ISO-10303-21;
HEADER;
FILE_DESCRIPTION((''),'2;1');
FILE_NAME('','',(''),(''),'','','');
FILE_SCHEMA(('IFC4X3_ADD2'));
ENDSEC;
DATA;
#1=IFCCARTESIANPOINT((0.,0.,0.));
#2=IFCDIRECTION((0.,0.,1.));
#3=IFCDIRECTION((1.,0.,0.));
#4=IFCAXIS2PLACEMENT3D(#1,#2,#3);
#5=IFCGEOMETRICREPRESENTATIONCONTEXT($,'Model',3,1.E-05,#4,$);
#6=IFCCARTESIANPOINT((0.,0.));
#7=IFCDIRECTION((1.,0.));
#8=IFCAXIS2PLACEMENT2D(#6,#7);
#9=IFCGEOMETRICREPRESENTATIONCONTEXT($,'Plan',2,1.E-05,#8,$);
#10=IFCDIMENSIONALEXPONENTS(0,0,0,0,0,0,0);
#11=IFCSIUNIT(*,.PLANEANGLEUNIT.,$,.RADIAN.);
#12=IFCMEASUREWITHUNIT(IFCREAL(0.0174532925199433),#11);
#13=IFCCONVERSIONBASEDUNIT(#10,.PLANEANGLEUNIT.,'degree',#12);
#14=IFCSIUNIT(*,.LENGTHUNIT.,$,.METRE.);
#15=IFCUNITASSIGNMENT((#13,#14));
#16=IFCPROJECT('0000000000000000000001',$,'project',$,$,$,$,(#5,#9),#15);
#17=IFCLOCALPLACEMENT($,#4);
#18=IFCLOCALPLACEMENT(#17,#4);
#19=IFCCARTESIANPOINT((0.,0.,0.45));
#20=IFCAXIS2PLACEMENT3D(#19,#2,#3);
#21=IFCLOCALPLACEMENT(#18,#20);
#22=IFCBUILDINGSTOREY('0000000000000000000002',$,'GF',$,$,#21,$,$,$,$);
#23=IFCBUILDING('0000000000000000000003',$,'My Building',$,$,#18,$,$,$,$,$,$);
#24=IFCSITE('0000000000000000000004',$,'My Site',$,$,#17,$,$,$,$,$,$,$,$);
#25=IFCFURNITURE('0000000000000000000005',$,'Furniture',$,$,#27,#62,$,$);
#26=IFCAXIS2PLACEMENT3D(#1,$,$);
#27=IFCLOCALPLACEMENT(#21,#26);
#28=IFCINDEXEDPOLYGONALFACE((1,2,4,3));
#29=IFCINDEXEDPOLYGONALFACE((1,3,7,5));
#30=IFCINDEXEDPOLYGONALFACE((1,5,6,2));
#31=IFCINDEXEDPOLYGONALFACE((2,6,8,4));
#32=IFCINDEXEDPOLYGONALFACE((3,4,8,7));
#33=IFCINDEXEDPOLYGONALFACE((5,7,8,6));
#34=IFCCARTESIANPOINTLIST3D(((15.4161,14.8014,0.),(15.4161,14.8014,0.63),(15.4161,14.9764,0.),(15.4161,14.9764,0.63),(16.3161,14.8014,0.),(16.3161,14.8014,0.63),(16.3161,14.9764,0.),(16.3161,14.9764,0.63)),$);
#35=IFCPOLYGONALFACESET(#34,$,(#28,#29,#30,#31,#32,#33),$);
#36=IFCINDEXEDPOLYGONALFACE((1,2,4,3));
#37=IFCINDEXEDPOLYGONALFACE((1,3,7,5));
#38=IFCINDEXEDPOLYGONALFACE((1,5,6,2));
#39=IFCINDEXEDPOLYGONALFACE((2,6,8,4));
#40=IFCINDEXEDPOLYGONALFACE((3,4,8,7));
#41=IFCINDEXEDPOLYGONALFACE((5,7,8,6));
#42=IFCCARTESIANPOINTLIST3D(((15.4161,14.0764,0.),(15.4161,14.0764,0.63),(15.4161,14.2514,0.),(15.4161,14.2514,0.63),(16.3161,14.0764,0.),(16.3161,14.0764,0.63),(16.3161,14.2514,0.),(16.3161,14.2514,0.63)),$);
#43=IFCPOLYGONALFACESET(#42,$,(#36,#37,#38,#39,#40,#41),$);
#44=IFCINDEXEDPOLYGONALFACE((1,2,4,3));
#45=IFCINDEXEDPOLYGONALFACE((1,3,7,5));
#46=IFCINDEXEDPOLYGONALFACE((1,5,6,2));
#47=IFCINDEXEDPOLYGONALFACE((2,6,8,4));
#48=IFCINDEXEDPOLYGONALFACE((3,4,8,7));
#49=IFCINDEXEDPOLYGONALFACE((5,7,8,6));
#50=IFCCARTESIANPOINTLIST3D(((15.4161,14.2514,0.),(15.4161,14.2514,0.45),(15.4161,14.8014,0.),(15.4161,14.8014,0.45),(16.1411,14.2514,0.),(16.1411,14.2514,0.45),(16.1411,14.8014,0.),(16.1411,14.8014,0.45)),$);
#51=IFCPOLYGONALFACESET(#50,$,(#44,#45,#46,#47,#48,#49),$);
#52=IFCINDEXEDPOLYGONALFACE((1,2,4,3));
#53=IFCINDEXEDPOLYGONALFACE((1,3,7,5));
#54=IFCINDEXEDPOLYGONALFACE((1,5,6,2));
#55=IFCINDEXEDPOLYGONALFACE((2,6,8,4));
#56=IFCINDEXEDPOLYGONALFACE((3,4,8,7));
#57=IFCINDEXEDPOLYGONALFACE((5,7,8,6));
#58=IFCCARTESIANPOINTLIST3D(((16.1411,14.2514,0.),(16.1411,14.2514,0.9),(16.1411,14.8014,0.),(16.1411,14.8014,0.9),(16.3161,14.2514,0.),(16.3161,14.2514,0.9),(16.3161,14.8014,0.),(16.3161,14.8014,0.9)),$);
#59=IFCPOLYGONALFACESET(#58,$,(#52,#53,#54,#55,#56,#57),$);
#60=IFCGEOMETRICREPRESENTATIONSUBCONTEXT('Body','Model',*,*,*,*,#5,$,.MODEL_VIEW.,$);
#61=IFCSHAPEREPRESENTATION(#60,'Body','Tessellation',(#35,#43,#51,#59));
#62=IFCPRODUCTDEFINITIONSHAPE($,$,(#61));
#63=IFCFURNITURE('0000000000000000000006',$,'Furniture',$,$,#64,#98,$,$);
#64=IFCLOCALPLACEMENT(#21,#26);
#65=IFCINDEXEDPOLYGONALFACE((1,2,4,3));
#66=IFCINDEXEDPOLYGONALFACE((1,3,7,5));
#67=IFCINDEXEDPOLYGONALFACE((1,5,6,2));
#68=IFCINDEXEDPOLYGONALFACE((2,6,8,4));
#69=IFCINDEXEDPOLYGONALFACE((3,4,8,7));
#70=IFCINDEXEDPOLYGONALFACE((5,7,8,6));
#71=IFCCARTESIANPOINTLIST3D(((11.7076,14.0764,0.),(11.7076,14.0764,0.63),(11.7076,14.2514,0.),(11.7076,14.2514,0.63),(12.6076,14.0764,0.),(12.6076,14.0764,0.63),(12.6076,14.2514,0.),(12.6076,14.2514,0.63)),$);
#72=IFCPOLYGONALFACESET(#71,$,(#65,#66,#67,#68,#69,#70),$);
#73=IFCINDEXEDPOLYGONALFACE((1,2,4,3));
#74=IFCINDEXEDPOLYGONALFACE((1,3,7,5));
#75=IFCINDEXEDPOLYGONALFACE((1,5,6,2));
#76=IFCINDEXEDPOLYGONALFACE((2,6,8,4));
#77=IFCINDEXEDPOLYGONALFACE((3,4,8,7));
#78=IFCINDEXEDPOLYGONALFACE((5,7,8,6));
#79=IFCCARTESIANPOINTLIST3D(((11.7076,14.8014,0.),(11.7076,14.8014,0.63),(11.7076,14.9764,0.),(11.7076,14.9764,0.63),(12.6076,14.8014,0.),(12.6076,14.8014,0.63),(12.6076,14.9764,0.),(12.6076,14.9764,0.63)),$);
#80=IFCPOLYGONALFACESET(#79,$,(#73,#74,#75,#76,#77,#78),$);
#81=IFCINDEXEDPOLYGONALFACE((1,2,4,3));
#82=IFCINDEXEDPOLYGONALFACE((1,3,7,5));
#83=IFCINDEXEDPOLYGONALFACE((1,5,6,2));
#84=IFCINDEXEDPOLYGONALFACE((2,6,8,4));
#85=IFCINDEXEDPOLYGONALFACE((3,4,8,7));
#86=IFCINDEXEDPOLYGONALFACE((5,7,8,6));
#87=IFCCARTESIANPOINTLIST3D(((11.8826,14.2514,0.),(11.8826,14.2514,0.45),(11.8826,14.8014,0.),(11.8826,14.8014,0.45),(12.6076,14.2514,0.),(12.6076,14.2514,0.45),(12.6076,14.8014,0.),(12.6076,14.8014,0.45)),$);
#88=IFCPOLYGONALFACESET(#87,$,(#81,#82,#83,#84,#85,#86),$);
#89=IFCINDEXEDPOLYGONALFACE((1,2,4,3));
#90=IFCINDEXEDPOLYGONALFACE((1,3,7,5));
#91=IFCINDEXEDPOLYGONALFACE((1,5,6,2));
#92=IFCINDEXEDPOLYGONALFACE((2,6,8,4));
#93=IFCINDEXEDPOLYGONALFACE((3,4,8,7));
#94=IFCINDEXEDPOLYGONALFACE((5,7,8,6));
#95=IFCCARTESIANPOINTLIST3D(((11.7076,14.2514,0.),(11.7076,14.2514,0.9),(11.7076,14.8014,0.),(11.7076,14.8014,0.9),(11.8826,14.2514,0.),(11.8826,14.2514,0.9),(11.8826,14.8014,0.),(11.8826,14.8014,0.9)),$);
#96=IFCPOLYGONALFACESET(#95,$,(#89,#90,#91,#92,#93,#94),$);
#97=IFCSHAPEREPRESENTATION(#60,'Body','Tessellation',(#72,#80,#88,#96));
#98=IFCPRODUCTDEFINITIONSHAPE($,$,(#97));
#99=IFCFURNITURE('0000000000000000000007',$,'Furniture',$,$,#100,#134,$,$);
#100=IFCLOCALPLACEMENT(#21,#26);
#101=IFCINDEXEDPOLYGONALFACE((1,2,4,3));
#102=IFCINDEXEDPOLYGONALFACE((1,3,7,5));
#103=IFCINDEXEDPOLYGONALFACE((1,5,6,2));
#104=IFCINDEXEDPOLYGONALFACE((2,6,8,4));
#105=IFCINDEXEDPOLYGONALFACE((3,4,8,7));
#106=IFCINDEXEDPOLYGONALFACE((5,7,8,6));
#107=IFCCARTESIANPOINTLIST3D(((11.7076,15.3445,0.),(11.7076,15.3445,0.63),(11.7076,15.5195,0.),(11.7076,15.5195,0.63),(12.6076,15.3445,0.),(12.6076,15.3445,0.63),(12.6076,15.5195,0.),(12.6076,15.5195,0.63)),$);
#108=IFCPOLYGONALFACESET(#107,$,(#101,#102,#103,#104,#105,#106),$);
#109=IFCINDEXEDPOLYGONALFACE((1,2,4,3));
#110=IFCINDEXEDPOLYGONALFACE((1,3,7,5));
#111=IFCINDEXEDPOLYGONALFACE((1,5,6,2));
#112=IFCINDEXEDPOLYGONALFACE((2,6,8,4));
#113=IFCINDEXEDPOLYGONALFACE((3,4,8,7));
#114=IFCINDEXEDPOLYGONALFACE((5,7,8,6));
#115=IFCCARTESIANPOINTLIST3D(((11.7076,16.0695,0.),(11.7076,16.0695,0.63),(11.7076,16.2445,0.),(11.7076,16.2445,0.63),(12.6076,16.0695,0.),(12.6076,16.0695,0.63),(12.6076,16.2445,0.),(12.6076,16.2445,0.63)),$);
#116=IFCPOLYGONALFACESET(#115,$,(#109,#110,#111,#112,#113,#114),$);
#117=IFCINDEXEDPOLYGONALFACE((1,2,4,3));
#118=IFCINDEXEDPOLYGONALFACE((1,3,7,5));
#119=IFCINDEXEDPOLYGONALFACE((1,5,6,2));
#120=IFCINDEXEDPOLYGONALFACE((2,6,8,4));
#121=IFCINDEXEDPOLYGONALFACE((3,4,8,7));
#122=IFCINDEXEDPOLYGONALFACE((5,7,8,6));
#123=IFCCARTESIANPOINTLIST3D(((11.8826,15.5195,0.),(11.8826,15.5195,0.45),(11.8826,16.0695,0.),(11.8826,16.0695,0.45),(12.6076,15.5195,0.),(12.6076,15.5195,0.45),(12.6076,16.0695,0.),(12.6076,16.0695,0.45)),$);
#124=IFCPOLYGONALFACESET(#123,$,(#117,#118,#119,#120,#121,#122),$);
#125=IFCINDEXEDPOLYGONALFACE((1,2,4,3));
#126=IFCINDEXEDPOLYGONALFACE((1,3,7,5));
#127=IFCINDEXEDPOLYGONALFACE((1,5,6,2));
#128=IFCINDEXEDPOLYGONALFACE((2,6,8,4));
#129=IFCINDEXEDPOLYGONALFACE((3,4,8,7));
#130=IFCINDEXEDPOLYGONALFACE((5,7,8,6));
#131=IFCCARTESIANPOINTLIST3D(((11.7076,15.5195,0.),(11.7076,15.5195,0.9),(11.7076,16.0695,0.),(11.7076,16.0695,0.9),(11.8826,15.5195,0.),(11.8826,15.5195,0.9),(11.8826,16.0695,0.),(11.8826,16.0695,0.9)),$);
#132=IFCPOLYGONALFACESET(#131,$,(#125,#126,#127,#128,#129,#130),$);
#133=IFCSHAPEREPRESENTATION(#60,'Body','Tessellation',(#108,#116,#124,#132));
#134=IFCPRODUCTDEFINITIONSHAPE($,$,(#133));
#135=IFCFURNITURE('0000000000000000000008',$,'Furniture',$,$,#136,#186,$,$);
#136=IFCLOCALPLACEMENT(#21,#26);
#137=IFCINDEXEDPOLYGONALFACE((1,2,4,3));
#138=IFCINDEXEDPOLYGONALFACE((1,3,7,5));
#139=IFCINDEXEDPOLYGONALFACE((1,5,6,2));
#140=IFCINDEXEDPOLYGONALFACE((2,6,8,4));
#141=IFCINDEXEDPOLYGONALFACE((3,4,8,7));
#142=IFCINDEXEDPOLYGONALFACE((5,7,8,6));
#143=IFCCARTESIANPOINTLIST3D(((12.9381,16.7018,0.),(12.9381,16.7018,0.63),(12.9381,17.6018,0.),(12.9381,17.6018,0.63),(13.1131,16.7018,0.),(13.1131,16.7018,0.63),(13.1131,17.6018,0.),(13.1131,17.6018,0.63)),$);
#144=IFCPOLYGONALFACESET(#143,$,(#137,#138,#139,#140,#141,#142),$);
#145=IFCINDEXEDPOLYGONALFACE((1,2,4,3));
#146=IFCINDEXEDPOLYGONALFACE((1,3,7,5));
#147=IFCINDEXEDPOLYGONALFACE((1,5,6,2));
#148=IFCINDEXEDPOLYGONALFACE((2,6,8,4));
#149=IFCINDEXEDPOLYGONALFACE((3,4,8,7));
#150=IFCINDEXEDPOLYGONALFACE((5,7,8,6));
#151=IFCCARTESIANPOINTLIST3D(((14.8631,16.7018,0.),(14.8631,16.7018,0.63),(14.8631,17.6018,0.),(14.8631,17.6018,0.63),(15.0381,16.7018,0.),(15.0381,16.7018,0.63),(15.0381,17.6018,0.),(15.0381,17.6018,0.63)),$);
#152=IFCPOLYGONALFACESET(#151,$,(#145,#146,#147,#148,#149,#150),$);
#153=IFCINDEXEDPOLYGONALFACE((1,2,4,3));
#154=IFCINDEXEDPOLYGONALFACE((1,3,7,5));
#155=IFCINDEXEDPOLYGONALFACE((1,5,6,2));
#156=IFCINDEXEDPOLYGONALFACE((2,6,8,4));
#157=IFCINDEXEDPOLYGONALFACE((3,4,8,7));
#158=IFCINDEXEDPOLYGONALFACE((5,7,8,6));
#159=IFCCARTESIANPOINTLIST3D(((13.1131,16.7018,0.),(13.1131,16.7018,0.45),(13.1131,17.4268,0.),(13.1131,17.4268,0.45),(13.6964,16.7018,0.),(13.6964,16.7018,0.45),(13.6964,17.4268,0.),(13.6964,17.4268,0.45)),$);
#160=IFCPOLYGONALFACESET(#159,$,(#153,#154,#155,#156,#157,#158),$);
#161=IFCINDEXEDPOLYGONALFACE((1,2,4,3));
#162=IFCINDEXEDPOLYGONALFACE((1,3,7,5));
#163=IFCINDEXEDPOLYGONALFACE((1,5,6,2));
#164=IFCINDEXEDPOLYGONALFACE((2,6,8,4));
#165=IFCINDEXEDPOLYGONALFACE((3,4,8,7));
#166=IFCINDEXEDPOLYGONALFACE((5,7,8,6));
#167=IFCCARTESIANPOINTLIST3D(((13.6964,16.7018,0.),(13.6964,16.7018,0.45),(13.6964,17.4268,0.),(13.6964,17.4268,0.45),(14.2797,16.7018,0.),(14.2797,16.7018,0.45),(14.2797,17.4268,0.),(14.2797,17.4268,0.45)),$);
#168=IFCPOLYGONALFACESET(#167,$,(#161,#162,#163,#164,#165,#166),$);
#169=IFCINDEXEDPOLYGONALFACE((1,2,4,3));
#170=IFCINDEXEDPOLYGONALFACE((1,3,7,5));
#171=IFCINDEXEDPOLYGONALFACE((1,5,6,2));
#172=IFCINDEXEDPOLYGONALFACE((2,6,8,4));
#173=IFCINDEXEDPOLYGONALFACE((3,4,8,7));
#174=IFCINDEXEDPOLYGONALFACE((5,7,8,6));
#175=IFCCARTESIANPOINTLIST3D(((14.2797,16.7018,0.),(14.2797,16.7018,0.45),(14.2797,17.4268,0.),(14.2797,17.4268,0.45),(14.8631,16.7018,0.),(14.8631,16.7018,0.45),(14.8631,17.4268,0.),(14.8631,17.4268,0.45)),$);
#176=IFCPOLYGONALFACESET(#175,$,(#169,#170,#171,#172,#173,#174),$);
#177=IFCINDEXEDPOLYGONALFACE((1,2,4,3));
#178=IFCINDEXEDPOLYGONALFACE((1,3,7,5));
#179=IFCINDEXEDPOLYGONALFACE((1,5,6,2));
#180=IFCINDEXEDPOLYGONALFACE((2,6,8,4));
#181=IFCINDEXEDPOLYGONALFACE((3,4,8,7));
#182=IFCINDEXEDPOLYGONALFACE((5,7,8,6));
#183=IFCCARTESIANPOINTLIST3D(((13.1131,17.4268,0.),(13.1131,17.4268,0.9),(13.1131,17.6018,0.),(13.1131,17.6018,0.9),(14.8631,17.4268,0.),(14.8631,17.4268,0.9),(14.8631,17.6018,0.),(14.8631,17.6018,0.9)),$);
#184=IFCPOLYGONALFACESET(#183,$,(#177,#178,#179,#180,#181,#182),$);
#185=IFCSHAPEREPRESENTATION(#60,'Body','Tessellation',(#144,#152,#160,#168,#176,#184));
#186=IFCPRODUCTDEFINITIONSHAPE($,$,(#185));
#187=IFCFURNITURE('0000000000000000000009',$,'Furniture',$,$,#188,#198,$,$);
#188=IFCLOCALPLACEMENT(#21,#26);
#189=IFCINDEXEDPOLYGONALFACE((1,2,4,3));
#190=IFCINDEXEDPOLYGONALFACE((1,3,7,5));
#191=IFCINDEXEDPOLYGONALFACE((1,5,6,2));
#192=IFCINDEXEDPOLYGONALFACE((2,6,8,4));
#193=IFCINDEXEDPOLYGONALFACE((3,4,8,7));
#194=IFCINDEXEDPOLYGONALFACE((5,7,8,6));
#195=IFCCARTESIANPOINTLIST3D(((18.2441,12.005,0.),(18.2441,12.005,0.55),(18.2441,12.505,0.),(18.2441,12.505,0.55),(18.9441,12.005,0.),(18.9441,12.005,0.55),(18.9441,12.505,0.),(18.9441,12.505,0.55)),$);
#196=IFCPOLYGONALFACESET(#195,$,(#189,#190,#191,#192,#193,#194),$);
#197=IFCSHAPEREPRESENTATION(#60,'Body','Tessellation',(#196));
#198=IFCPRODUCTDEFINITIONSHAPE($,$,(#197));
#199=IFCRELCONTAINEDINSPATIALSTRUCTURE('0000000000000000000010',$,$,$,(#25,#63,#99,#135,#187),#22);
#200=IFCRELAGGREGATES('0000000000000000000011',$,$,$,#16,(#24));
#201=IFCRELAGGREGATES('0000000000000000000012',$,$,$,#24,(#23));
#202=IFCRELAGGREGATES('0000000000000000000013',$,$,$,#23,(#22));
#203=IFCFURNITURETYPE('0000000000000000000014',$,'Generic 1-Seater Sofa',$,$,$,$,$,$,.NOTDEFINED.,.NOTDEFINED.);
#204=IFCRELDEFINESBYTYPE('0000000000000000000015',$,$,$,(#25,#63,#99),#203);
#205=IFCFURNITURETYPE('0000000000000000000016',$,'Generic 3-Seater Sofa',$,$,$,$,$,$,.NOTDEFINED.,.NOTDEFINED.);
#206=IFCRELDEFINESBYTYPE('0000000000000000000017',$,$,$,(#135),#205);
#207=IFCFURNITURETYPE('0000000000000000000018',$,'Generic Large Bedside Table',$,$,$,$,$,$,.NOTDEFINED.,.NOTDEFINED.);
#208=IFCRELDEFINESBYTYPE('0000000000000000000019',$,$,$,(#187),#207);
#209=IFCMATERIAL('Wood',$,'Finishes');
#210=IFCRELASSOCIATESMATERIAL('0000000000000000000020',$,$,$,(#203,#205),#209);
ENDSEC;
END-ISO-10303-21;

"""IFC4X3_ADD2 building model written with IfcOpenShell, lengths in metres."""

from ifc_helpers import new_model, entity, si_unit, converted_unit, frame, origin_with_axes, origin_2d_with_axis, place, context, subcontext, project, spatial, line, indexed_curve, outline, extrude, shape, source, transform, mapped, material, type_object, type_shapes, element, save


model = new_model("IFC4X3_ADD2")

# Units and contexts
model_context = context("Model", 3, precision=1e-05, world=origin_with_axes())
plan_context = context("Plan", 2, precision=1e-05, world=origin_2d_with_axis())
body_context_1 = subcontext(model_context, "Body", "Model", "MODEL_VIEW")
body_context_2 = subcontext(plan_context, "Body", "Plan", "PLAN_VIEW")
ifc_project = project(units=[converted_unit("PLANEANGLEUNIT", "degree", entity("IfcReal", 0.0174532925199433), si_unit("PLANEANGLEUNIT", "RADIAN"), dimensions=[0, 0, 0, 0, 0, 0, 0]), si_unit("LENGTHUNIT", "METRE")], contexts=[model_context, plan_context])

# Site, building, storey
site_placement = place(None, origin_with_axes())
site = spatial("IfcSite", under=ifc_project, at=site_placement, Name="My Site")
building_placement = place(site_placement, origin_with_axes())
building = spatial("IfcBuilding", under=site, at=building_placement, Name="My Building")
storey_placement = place(building_placement, frame((0.0, 0.0, 0.45), z_axis=(0.0, 0.0, 1.0), x_axis=(1.0, 0.0, 0.0)))
storey = spatial("IfcBuildingStorey", under=building, at=storey_placement, Name="GF")

# Furniture
ifc_material_1 = material(Name="Wood", Category="Finishes")
furniture_type_1 = type_object("IfcFurnitureType", Name="Generic 1-Seater Sofa", AssemblyPlace="NOTDEFINED", PredefinedType="NOTDEFINED", material=ifc_material_1)
shared_shape_1 = source(origin_with_axes(), body_context_1, "Body", "SweptSolid", [
    extrude(outline(indexed_curve([(0.0, 0.0), (0.175, 0.0), (0.175, 0.9), (0.0, 0.9)], segments=[line(1, 2, 3, 4, 1)])), frame((-0.45, -0.9, 0.0), z_axis=(0.0, 0.0, 1.0), x_axis=(1.0, 0.0, 0.0)), (0.0, 0.0, 1.0), 0.63),
    extrude(outline(indexed_curve([(0.0, 0.0), (0.175, 0.0), (0.175, 0.9), (0.0, 0.9)], segments=[line(1, 2, 3, 4, 1)])), frame((0.275, -0.9, 0.0), z_axis=(0.0, 0.0, 1.0), x_axis=(1.0, 0.0, 0.0)), (0.0, 0.0, 1.0), 0.63),
    extrude(outline(indexed_curve([(0.175, 0.0), (0.725, 0.0), (0.725, 0.725), (0.175, 0.725)], segments=[line(1, 2, 3, 4, 1)])), frame((-0.45, -0.9, 0.0), z_axis=(0.0, 0.0, 1.0), x_axis=(1.0, 0.0, 0.0)), (0.0, 0.0, 1.0), 0.45),
    extrude(outline(indexed_curve([(0.175, 0.9), (0.175, 0.725), (0.725, 0.725), (0.725, 0.9), (0.175, 0.9)])), frame((-0.45, -0.9, 0.0), z_axis=(0.0, 0.0, 1.0), x_axis=(1.0, 0.0, 0.0)), (0.0, 0.0, 1.0), 0.9),
])
shared_shape_2 = source(origin_with_axes(), body_context_2, "Body", "Annotation2D", [
    entity("IfcGeometricCurveSet", [entity("IfcIndexedPolyCurve", entity("IfcCartesianPointList2D", [[0.275, -0.175], [0.275, -0.9], [0.45, -0.9], [0.45, 0.0], [0.275, 0.0], [0.275, -0.9], [-0.275, -0.9], [-0.275, 0.0], [-0.275, -0.175], [0.275, -0.175], [0.275, 0.0], [-0.275, 0.0], [-0.45, 0.0], [-0.45, -0.9], [-0.275, -0.9], [-0.275, -0.175]]))]),
])
type_shapes(furniture_type_1, [shared_shape_1, shared_shape_2])
for number, where, z_axis, x_axis, name in (
    (1, (16.3161, 14.5264, 0.0), (0.0, 0.0, 1.0), (0.0, -1.0, 0.0), "Furniture"),
    (2, (11.7076, 14.5264, 0.0), (0.0, 0.0, 1.0), (0.000003, 1.0, 0.0), "Furniture"),
    (3, (11.7076, 15.7945, 0.0), (0.0, 0.0, 1.0), (0.000003, 1.0, 0.0), "Furniture"),
):
    element("IfcFurniture", number, at=place(storey_placement, frame(where, z_axis=z_axis, x_axis=x_axis)), inside=storey, type_object=furniture_type_1, Name=name, shapes=[
        shape(body_context_1, "Body", "MappedRepresentation", [mapped(shared_shape_1, transform((0.0, 0.0, 0.0), x_axis=(1.0, 0.0, 0.0), y_axis=(0.0, 1.0, 0.0), z_axis=(0.0, 0.0, 1.0), scale=1.0))]),
        shape(body_context_2, "Body", "MappedRepresentation", [mapped(shared_shape_2, transform((0.0, 0.0, 0.0), x_axis=(1.0, 0.0, 0.0), y_axis=(0.0, 1.0, 0.0), z_axis=(0.0, 0.0, 1.0), scale=1.0))]),
    ])
furniture_type_2 = type_object("IfcFurnitureType", Name="Generic 3-Seater Sofa", AssemblyPlace="NOTDEFINED", PredefinedType="NOTDEFINED", material=ifc_material_1)
shared_shape_3 = source(origin_with_axes(), body_context_1, "Body", "SweptSolid", [
    extrude(outline(indexed_curve([(0.0, 0.0), (0.175, 0.0), (0.175, 0.9), (0.0, 0.9)], segments=[line(1, 2, 3, 4, 1)])), frame((-1.05, -0.9, 0.0), z_axis=(0.0, 0.0, 1.0), x_axis=(1.0, 0.0, 0.0)), (0.0, 0.0, 1.0), 0.63),
    extrude(outline(indexed_curve([(0.0, 0.0), (0.175, 0.0), (0.175, 0.9), (0.0, 0.9)], segments=[line(1, 2, 3, 4, 1)])), frame((0.875, -0.9, 0.0), z_axis=(0.0, 0.0, 1.0), x_axis=(1.0, 0.0, 0.0)), (0.0, 0.0, 1.0), 0.63),
    extrude(outline(indexed_curve([(0.175, 0.0), (0.7583, 0.0), (0.7583, 0.725), (0.175, 0.725)], segments=[line(1, 2, 3, 4, 1)])), frame((-1.05, -0.9, 0.0), z_axis=(0.0, 0.0, 1.0), x_axis=(1.0, 0.0, 0.0)), (0.0, 0.0, 1.0), 0.45),
    extrude(outline(indexed_curve([(0.7583, 0.0), (1.3417, 0.0), (1.3417, 0.725), (0.7583, 0.725)], segments=[line(1, 2, 3, 4, 1)])), frame((-1.05, -0.9, 0.0), z_axis=(0.0, 0.0, 1.0), x_axis=(1.0, 0.0, 0.0)), (0.0, 0.0, 1.0), 0.45),
    extrude(outline(indexed_curve([(1.3417, 0.0), (1.925, 0.0), (1.925, 0.725), (1.3417, 0.725)], segments=[line(1, 2, 3, 4, 1)])), frame((-1.05, -0.9, 0.0), z_axis=(0.0, 0.0, 1.0), x_axis=(1.0, 0.0, 0.0)), (0.0, 0.0, 1.0), 0.45),
    extrude(outline(indexed_curve([(0.175, 0.725), (1.925, 0.725), (1.925, 0.9), (0.175, 0.9)], segments=[line(1, 2, 3, 4, 1)])), frame((-1.05, -0.9, 0.0), z_axis=(0.0, 0.0, 1.0), x_axis=(1.0, 0.0, 0.0)), (0.0, 0.0, 1.0), 0.9),
])
shared_shape_4 = source(origin_with_axes(), body_context_2, "Body", "Curve2D", [
    entity("IfcIndexedPolyCurve", entity("IfcCartesianPointList2D", [[-1.05, -0.9], [-0.875, -0.9], [-0.875, 0.0], [-1.05, 0.0]]), [entity("IfcLineIndex", [1, 2, 3, 4, 1])]),
    entity("IfcIndexedPolyCurve", entity("IfcCartesianPointList2D", [[0.875, -0.9], [1.05, -0.9], [1.05, 0.0], [0.875, 0.0]]), [entity("IfcLineIndex", [1, 2, 3, 4, 1])]),
    entity("IfcIndexedPolyCurve", entity("IfcCartesianPointList2D", [[-0.875, -0.9], [-0.2917, -0.9], [-0.2917, -0.175], [-0.875, -0.175]]), [entity("IfcLineIndex", [1, 2, 3, 4, 1])]),
    entity("IfcIndexedPolyCurve", entity("IfcCartesianPointList2D", [[-0.2917, -0.9], [0.2917, -0.9], [0.2917, -0.175], [-0.2917, -0.175]]), [entity("IfcLineIndex", [1, 2, 3, 4, 1])]),
    entity("IfcIndexedPolyCurve", entity("IfcCartesianPointList2D", [[0.2917, -0.9], [0.875, -0.9], [0.875, -0.175], [0.2917, -0.175]]), [entity("IfcLineIndex", [1, 2, 3, 4, 1])]),
    entity("IfcIndexedPolyCurve", entity("IfcCartesianPointList2D", [[-0.875, -0.175], [0.875, -0.175], [0.875, 0.0], [-0.875, 0.0]]), [entity("IfcLineIndex", [1, 2, 3, 4, 1])]),
])
type_shapes(furniture_type_2, [shared_shape_3, shared_shape_4])
furniture_1_placement = place(storey_placement, frame((13.9881, 17.6018, 0.0), z_axis=(0.0, 0.0, 1.0), x_axis=(1.0, 0.0, 0.0)))
element("IfcFurniture", 4, at=furniture_1_placement, inside=storey, type_object=furniture_type_2, Name="Furniture", shapes=[
    shape(body_context_1, "Body", "MappedRepresentation", [mapped(shared_shape_3, transform((0.0, 0.0, 0.0), x_axis=(1.0, 0.0, 0.0), y_axis=(0.0, 1.0, 0.0), z_axis=(0.0, 0.0, 1.0), scale=1.0))]),
    shape(body_context_2, "Body", "MappedRepresentation", [mapped(shared_shape_4, transform((0.0, 0.0, 0.0), x_axis=(1.0, 0.0, 0.0), y_axis=(0.0, 1.0, 0.0), z_axis=(0.0, 0.0, 1.0), scale=1.0))]),
])
furniture_type_3 = type_object("IfcFurnitureType", Name="Generic Large Bedside Table", AssemblyPlace="NOTDEFINED", PredefinedType="NOTDEFINED")
shared_shape_5 = source(origin_with_axes(), body_context_1, "Body", "SweptSolid", [
    extrude(outline(indexed_curve([(0.0, 0.0), (0.7, 0.0), (0.7, 0.5), (0.0, 0.5)], segments=[line(1, 2, 3, 4, 1)])), frame((-0.35, -0.25, 0.0), z_axis=(0.0, 0.0, 1.0), x_axis=(1.0, 0.0, 0.0)), (0.0, 0.0, 1.0), 0.55),
])
shared_shape_6 = source(origin_with_axes(), body_context_2, "Body", "Curve2D", [
    entity("IfcIndexedPolyCurve", entity("IfcCartesianPointList2D", [[-0.35, -0.25], [0.35, -0.25], [0.35, 0.25], [-0.35, 0.25]]), [entity("IfcLineIndex", [1, 2, 3, 4, 1])]),
])
type_shapes(furniture_type_3, [shared_shape_5, shared_shape_6])
for number, where, z_axis, x_axis, name in (
    (5, (18.5941, 12.255, 0.0), (0.0, 0.0, 1.0), (1.0, 0.0, 0.0), "Furniture"),
):
    element("IfcFurniture", number, at=place(storey_placement, frame(where, z_axis=z_axis, x_axis=x_axis)), inside=storey, type_object=furniture_type_3, Name=name, shapes=[
        shape(body_context_1, "Body", "MappedRepresentation", [mapped(shared_shape_5, transform((0.0, 0.0, 0.0), x_axis=(1.0, 0.0, 0.0), y_axis=(0.0, 1.0, 0.0), z_axis=(0.0, 0.0, 1.0), scale=1.0))]),
        shape(body_context_2, "Body", "MappedRepresentation", [mapped(shared_shape_6, transform((0.0, 0.0, 0.0), x_axis=(1.0, 0.0, 0.0), y_axis=(0.0, 1.0, 0.0), z_axis=(0.0, 0.0, 1.0), scale=1.0))]),
    ])

save(model, "model.ifc")
